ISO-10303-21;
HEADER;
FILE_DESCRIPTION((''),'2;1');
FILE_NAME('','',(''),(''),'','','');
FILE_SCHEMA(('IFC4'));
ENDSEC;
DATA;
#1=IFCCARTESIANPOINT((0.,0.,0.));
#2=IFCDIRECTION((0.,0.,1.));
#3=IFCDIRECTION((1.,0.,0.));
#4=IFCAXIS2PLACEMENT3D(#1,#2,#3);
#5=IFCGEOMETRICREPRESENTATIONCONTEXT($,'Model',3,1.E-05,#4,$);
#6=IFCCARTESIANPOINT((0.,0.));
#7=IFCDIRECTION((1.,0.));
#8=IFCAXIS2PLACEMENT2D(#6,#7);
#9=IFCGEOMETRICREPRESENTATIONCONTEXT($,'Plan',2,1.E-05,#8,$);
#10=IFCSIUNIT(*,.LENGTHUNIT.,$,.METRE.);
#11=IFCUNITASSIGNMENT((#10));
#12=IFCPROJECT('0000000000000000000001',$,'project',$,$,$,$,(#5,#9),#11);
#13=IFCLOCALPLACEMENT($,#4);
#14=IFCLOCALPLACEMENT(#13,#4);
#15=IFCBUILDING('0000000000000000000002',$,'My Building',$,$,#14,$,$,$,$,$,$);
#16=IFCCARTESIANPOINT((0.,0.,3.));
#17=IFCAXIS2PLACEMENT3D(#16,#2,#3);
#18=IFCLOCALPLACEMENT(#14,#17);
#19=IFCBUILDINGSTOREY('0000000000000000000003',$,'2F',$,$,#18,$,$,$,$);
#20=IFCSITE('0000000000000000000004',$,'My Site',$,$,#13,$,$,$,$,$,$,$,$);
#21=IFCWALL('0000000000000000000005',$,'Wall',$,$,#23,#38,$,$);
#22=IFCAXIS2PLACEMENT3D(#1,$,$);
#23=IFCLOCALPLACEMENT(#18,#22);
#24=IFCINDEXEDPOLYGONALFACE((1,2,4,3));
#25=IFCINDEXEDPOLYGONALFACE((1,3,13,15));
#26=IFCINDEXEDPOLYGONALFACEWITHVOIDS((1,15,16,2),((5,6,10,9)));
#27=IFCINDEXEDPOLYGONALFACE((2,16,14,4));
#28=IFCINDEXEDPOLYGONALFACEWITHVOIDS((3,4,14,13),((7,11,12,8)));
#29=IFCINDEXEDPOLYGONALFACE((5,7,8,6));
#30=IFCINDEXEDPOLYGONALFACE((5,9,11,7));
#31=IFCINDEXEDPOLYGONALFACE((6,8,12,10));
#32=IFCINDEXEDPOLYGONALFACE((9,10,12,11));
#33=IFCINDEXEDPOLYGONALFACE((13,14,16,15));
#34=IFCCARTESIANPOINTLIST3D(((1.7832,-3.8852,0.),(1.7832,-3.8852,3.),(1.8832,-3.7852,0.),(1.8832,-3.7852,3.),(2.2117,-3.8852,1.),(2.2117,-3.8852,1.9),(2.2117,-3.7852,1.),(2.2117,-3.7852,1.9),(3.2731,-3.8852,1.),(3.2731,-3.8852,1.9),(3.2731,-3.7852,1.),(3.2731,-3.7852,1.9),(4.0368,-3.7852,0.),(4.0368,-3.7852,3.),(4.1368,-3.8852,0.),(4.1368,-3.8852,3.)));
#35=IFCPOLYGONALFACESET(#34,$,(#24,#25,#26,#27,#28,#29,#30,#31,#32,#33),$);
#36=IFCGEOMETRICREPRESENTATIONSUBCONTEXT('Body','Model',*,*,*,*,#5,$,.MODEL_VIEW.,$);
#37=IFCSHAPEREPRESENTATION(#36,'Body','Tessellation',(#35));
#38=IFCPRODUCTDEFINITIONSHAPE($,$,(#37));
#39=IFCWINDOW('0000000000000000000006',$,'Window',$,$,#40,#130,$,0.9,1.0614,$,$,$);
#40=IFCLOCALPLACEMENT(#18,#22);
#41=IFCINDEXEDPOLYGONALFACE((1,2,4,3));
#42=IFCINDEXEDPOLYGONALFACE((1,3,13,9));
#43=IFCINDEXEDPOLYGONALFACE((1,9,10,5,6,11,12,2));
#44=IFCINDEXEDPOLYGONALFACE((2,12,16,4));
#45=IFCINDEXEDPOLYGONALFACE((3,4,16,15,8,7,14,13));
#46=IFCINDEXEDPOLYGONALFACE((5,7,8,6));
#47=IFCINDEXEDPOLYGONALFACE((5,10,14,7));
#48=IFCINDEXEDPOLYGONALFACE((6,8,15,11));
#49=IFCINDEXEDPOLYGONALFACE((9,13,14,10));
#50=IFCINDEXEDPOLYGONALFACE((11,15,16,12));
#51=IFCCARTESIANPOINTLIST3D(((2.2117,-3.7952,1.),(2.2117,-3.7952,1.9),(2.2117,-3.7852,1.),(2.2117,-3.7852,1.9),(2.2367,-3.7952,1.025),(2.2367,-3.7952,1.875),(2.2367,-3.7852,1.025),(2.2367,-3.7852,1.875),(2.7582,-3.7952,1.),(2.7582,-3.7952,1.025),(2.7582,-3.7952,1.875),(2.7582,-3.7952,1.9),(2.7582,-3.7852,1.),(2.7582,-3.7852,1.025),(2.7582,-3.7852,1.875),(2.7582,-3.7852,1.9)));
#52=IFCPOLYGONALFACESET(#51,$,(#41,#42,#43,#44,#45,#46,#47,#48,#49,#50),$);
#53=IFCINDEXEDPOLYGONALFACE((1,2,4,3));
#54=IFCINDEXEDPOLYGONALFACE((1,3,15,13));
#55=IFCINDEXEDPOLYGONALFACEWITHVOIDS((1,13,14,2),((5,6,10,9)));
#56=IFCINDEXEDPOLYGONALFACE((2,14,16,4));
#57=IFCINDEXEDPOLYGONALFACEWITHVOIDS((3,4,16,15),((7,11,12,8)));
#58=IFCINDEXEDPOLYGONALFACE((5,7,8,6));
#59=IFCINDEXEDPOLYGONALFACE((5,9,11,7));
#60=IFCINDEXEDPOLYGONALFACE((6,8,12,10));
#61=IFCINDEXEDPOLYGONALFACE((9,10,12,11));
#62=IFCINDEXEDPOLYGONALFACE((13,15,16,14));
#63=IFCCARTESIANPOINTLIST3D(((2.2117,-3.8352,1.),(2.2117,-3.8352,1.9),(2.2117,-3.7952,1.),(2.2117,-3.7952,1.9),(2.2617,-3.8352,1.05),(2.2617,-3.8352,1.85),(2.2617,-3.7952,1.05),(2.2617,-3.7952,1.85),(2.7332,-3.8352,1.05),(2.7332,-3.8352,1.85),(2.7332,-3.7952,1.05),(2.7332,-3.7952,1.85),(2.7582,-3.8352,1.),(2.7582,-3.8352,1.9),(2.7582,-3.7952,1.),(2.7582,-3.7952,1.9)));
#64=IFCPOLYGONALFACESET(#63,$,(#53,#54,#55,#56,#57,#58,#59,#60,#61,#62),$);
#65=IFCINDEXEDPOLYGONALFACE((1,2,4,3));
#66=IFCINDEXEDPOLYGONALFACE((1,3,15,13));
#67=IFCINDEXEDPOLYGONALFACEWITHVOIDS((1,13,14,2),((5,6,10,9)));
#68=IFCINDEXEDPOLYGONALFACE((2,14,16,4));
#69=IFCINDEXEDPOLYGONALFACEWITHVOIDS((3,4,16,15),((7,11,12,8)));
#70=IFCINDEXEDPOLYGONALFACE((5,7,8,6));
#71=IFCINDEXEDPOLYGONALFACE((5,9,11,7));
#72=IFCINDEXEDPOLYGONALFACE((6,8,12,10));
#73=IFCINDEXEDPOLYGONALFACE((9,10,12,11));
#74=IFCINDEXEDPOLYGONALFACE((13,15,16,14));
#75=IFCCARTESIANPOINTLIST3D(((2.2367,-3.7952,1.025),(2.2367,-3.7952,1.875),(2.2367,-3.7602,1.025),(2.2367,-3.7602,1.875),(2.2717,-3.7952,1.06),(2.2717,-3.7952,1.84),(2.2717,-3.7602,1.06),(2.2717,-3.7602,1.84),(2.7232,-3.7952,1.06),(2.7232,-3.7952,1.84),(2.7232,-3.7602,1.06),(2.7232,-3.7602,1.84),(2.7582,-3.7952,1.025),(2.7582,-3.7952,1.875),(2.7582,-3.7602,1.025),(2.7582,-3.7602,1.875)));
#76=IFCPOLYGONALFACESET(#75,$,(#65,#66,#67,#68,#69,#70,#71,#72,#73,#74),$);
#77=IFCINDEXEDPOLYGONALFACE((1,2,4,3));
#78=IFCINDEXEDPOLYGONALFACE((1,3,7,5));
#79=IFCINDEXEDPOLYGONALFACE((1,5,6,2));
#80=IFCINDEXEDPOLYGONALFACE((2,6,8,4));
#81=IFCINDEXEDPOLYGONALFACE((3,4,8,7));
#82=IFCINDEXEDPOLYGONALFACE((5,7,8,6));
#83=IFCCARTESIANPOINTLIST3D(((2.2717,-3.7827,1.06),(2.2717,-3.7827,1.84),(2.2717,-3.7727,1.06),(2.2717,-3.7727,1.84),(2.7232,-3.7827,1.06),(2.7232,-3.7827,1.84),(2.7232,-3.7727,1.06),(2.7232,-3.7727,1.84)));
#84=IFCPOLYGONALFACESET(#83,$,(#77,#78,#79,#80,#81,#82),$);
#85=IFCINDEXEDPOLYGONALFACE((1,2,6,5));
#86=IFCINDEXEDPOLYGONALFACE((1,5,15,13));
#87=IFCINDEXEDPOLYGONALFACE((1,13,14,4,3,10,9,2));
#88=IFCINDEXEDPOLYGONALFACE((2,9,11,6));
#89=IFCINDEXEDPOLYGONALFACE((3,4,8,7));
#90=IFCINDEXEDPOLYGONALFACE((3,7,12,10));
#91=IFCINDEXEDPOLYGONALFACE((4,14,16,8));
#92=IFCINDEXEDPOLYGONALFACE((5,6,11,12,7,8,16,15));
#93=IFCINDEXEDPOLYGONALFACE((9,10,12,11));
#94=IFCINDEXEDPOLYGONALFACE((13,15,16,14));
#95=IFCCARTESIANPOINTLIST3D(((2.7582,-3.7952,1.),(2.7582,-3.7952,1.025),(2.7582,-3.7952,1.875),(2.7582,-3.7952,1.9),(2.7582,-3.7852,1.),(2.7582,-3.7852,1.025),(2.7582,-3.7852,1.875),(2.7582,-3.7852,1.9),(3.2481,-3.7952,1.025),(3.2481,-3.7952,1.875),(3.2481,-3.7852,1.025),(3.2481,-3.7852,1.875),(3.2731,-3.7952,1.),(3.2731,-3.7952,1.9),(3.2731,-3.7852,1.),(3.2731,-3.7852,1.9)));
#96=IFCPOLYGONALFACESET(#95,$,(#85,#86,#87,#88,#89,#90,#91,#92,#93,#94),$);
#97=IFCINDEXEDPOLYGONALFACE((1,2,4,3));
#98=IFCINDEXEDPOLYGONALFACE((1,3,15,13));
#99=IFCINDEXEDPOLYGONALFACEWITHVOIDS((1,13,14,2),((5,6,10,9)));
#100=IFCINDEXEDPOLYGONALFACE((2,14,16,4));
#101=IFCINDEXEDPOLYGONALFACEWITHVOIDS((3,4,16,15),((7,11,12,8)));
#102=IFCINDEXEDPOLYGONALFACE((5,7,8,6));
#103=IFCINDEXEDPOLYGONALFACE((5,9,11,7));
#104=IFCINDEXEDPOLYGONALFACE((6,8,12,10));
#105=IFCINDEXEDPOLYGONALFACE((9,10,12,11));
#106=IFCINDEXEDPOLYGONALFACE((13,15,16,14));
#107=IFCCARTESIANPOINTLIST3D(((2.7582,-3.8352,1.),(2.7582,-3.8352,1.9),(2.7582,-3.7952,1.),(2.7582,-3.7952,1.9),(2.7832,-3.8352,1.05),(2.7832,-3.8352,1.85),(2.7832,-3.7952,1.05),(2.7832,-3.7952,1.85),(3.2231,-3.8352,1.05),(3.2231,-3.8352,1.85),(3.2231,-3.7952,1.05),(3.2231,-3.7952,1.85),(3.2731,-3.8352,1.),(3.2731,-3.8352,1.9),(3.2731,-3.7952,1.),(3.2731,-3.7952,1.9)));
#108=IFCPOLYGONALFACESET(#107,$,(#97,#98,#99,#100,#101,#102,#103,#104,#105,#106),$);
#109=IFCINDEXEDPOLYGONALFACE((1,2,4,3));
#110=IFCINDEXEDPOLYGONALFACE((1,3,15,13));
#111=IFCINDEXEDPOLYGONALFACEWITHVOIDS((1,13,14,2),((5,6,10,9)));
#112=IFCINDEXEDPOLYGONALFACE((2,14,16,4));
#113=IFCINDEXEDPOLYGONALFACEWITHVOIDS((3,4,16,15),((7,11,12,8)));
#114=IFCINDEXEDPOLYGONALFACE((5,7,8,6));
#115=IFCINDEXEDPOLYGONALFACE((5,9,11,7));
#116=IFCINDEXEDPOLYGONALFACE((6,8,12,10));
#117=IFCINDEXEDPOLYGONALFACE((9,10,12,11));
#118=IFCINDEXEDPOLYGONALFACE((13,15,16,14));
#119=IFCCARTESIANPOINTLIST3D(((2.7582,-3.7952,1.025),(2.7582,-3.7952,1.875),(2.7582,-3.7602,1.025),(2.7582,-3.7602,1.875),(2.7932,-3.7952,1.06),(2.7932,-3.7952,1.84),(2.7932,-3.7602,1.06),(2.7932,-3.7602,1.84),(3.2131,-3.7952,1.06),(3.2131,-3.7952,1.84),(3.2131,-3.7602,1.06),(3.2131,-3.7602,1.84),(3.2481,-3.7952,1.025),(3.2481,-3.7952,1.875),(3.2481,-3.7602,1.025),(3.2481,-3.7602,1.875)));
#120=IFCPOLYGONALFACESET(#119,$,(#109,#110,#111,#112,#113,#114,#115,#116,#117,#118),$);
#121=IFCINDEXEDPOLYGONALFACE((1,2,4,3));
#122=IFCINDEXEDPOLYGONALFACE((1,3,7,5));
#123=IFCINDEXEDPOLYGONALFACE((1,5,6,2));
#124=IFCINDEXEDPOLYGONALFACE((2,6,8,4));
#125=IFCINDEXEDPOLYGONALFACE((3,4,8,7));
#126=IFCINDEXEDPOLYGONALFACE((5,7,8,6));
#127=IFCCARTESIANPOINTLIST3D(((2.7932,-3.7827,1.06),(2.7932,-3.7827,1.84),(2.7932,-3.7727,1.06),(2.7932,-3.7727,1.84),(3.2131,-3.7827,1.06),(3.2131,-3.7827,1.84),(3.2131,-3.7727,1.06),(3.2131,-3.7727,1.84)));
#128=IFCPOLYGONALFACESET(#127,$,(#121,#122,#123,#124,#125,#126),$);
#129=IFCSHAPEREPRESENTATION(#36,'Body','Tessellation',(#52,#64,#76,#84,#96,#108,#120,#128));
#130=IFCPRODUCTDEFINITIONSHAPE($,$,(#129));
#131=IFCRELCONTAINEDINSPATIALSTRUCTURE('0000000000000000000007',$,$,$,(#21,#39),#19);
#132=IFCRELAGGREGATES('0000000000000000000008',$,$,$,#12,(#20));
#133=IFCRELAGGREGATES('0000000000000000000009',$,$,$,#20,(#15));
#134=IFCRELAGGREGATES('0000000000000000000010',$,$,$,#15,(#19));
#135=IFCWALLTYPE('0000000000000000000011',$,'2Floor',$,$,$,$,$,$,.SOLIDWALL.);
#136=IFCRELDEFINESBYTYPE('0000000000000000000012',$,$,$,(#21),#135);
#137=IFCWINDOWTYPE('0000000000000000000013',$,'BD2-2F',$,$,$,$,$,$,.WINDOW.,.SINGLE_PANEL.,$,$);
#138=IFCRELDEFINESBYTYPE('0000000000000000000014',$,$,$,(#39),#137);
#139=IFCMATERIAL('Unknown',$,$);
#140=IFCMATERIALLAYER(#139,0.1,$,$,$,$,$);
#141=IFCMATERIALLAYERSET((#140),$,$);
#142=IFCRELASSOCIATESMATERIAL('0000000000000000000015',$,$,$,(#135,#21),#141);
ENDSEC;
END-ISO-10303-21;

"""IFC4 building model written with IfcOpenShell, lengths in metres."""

from ifc_helpers import new_model, entity, si_unit, frame, origin_with_axes, origin_2d_with_axis, place, context, subcontext, project, spatial, line, indexed_curve, outline, extrude, shape, source, transform, mapped, material, layer, layer_set, layer_usage, type_object, type_shapes, element, fill, save


model = new_model("IFC4")

# Units and contexts
model_context = context("Model", 3, precision=1e-05, world=origin_with_axes())
plan_context = context("Plan", 2, precision=1e-05, world=origin_2d_with_axis())
body_context_1 = subcontext(model_context, "Body", "Model", "MODEL_VIEW")
body_context_2 = subcontext(plan_context, "Body", "Plan", "PLAN_VIEW")
ifc_project = project(units=[si_unit("LENGTHUNIT", "METRE")], contexts=[model_context, plan_context])

# Site, building, storey
site_placement = place(None, origin_with_axes())
site = spatial("IfcSite", under=ifc_project, at=site_placement, Name="My Site")
building_placement = place(site_placement, origin_with_axes())
building = spatial("IfcBuilding", under=site, at=building_placement, Name="My Building")
storey_placement = place(building_placement, frame((0.0, 0.0, 3.0), z_axis=(0.0, 0.0, 1.0), x_axis=(1.0, 0.0, 0.0)))
storey = spatial("IfcBuildingStorey", under=building, at=storey_placement, Name="2F")

# Shared definitions
ifc_material = material(Name="Unknown")

# Shared definitions
ifc_layer_1 = layer(ifc_material, 0.1)
ifc_layer_set_1 = layer_set([ifc_layer_1])
wall_type = type_object("IfcWallType", Name="2Floor", PredefinedType="SOLIDWALL", material=ifc_layer_set_1)

# Wall, opening, window
ifc_layer_usage_1 = layer_usage(ifc_layer_set_1, "AXIS2", "POSITIVE", 0.0)
wall_1_placement = place(storey_placement, frame((1.7832, -3.8852, 0.0), z_axis=(0.0, 0.0, 1.0), x_axis=(1.0, 0.000014, 0.0)))
wall_1 = element("IfcWall", 1, at=wall_1_placement, inside=storey, type_object=wall_type, material=ifc_layer_usage_1, Name="Wall", context=body_context_1, shape_type="SweptSolid", body=[
    extrude(outline(indexed_curve([(0.0, 0.0), (0.1, 0.1), (2.2537, 0.1), (2.3537, 0.0)], segments=[line(1, 2, 3, 4, 1)])), origin_with_axes(), (0.0, 0.0, 1.0), 3.0),
])
shared_shape_1 = source(origin_with_axes(), body_context_1, "Body", "SweptSolid", [
    extrude(outline(indexed_curve([(0.0, 0.0), (1.0614, 0.0), (1.0614, 0.9), (0.0, 0.9)], segments=[line(1, 2, 3, 4, 1)])), frame((0.0, -0.6, 0.0), z_axis=(0.0, -1.0, 0.0), x_axis=(1.0, 0.0, 0.0)), (0.0, 0.0, -1.0), 1.2),
])
opening_1_placement = place(wall_1_placement, frame((0.4285, 0.0, 1.0), z_axis=(0.0, 0.0, 1.0), x_axis=(1.0, 0.0, 0.0)))
opening_1 = element("IfcOpeningElement", 2, at=opening_1_placement, cuts=wall_1, PredefinedType="OPENING", context=body_context_1, shape_type="MappedRepresentation", body=[
    mapped(shared_shape_1, transform((0.0, 0.0, 0.0), x_axis=(1.0, 0.0, 0.0), y_axis=(0.0, 1.0, 0.0), z_axis=(0.0, 0.0, 1.0), scale=1.0)),
])
window_type_1 = type_object("IfcWindowType", Name="BD2-2F", PartitioningType="SINGLE_PANEL", PredefinedType="WINDOW")
shared_shape_2 = source(origin_with_axes(), body_context_1, "Body", "SweptSolid", [
    extrude(outline(indexed_curve([(0.5465, 0.0), (0.0, 0.0), (0.0, 0.9), (0.5465, 0.9), (0.5465, 0.875), (0.025, 0.875), (0.025, 0.025), (0.5465, 0.025)], segments=[line(1, 2, 3, 4, 5, 6, 7, 8, 1)])), frame((0.0, 0.09, 0.0), z_axis=(0.0, -1.0, 0.0), x_axis=(1.0, 0.0, 0.0)), (0.0, 0.0, -1.0), 0.01),
    extrude(outline(indexed_curve([(0.0, 0.0), (0.5465, 0.0), (0.5465, 0.9), (0.0, 0.9)], segments=[line(1, 2, 3, 4, 1)]), holes=[indexed_curve([(0.05, 0.05), (0.5215, 0.05), (0.5215, 0.85), (0.05, 0.85)], segments=[line(1, 2, 3, 4, 1)])]), frame((0.0, 0.05, 0.0), z_axis=(0.0, -1.0, 0.0), x_axis=(1.0, 0.0, 0.0)), (0.0, 0.0, -1.0), 0.04),
    extrude(outline(indexed_curve([(0.0, 0.0), (0.5215, 0.0), (0.5215, 0.85), (0.0, 0.85)], segments=[line(1, 2, 3, 4, 1)]), holes=[indexed_curve([(0.035, 0.035), (0.4865, 0.035), (0.4865, 0.815), (0.035, 0.815)], segments=[line(1, 2, 3, 4, 1)])]), frame((0.025, 0.09, 0.025), z_axis=(0.0, -1.0, 0.0), x_axis=(1.0, 0.0, 0.0)), (0.0, 0.0, -1.0), 0.035),
    extrude(outline(indexed_curve([(0.035, 0.035), (0.4865, 0.035), (0.4865, 0.815), (0.035, 0.815)], segments=[line(1, 2, 3, 4, 1)])), frame((0.025, 0.1025, 0.025), z_axis=(0.0, -1.0, 0.0), x_axis=(1.0, 0.0, 0.0)), (0.0, 0.0, -1.0), 0.01),
    extrude(outline(indexed_curve([(0.0, 0.9), (0.5149, 0.9), (0.5149, 0.0), (0.0, 0.0), (0.0, 0.025), (0.4899, 0.025), (0.4899, 0.875), (0.0, 0.875)], segments=[line(1, 2, 3, 4, 5, 6, 7, 8, 1)])), frame((0.5465, 0.09, 0.0), z_axis=(0.0, -1.0, 0.0), x_axis=(1.0, 0.0, 0.0)), (0.0, 0.0, -1.0), 0.01),
    extrude(outline(indexed_curve([(0.0, 0.0), (0.5149, 0.0), (0.5149, 0.9), (0.0, 0.9)], segments=[line(1, 2, 3, 4, 1)]), holes=[indexed_curve([(0.025, 0.05), (0.4649, 0.05), (0.4649, 0.85), (0.025, 0.85)], segments=[line(1, 2, 3, 4, 1)])]), frame((0.5465, 0.05, 0.0), z_axis=(0.0, -1.0, 0.0), x_axis=(1.0, 0.0, 0.0)), (0.0, 0.0, -1.0), 0.04),
    extrude(outline(indexed_curve([(0.0, 0.0), (0.4899, 0.0), (0.4899, 0.85), (0.0, 0.85)], segments=[line(1, 2, 3, 4, 1)]), holes=[indexed_curve([(0.035, 0.035), (0.4549, 0.035), (0.4549, 0.815), (0.035, 0.815)], segments=[line(1, 2, 3, 4, 1)])]), frame((0.5465, 0.09, 0.025), z_axis=(0.0, -1.0, 0.0), x_axis=(1.0, 0.0, 0.0)), (0.0, 0.0, -1.0), 0.035),
    extrude(outline(indexed_curve([(0.035, 0.035), (0.4549, 0.035), (0.4549, 0.815), (0.035, 0.815)], segments=[line(1, 2, 3, 4, 1)])), frame((0.5465, 0.1025, 0.025), z_axis=(0.0, -1.0, 0.0), x_axis=(1.0, 0.0, 0.0)), (0.0, 0.0, -1.0), 0.01),
])
shared_shape_3 = source(origin_with_axes(), body_context_2, "Body", "Curve2D", [
    entity("IfcIndexedPolyCurve", entity("IfcCartesianPointList2D", [[0.05, 0.05], [0.5215, 0.05]])),
    entity("IfcIndexedPolyCurve", entity("IfcCartesianPointList2D", [[0.0, 0.1], [0.025, 0.1], [0.025, 0.09], [0.05, 0.09], [0.05, 0.05], [0.0, 0.05]]), [entity("IfcLineIndex", [1, 2, 3, 4, 5, 6, 1])]),
    entity("IfcIndexedPolyCurve", entity("IfcCartesianPointList2D", [[0.5465, 0.1], [0.5465, 0.1], [0.5465, 0.09], [0.5215, 0.09], [0.5215, 0.05], [0.5465, 0.05]])),
    entity("IfcIndexedPolyCurve", entity("IfcCartesianPointList2D", [[0.025, 0.09], [0.06, 0.09], [0.06, 0.125], [0.025, 0.125]]), [entity("IfcLineIndex", [1, 2, 3, 4, 1])]),
    entity("IfcIndexedPolyCurve", entity("IfcCartesianPointList2D", [[0.5465, 0.09], [0.5115, 0.09], [0.5115, 0.125], [0.5465, 0.125]]), [entity("IfcLineIndex", [1, 2, 3, 4, 1])]),
    entity("IfcIndexedPolyCurve", entity("IfcCartesianPointList2D", [[0.06, 0.09], [0.5115, 0.09]])),
    entity("IfcIndexedPolyCurve", entity("IfcCartesianPointList2D", [[0.06, 0.125], [0.5115, 0.125]])),
    entity("IfcIndexedPolyCurve", entity("IfcCartesianPointList2D", [[0.06, 0.1075], [0.5115, 0.1075]])),
    entity("IfcIndexedPolyCurve", entity("IfcCartesianPointList2D", [[0.5715, 0.05], [1.0114, 0.05]])),
    entity("IfcIndexedPolyCurve", entity("IfcCartesianPointList2D", [[0.5465, 0.1], [0.5465, 0.1], [0.5465, 0.09], [0.5715, 0.09], [0.5715, 0.05], [0.5465, 0.05]])),
    entity("IfcIndexedPolyCurve", entity("IfcCartesianPointList2D", [[1.0614, 0.1], [1.0364, 0.1], [1.0364, 0.09], [1.0114, 0.09], [1.0114, 0.05], [1.0614, 0.05]]), [entity("IfcLineIndex", [1, 2, 3, 4, 5, 6, 1])]),
    entity("IfcIndexedPolyCurve", entity("IfcCartesianPointList2D", [[0.5465, 0.09], [0.5815, 0.09], [0.5815, 0.125], [0.5465, 0.125]]), [entity("IfcLineIndex", [1, 2, 3, 4, 1])]),
    entity("IfcIndexedPolyCurve", entity("IfcCartesianPointList2D", [[1.0364, 0.09], [1.0014, 0.09], [1.0014, 0.125], [1.0364, 0.125]]), [entity("IfcLineIndex", [1, 2, 3, 4, 1])]),
    entity("IfcIndexedPolyCurve", entity("IfcCartesianPointList2D", [[0.5815, 0.09], [1.0014, 0.09]])),
    entity("IfcIndexedPolyCurve", entity("IfcCartesianPointList2D", [[0.5815, 0.125], [1.0014, 0.125]])),
    entity("IfcIndexedPolyCurve", entity("IfcCartesianPointList2D", [[0.5815, 0.1075], [1.0014, 0.1075]])),
])
type_shapes(window_type_1, [shared_shape_2, shared_shape_3])
window_1_placement = place(opening_1_placement, frame((0.0, 0.0, 0.0), z_axis=(0.0, 0.0, 1.0), x_axis=(1.0, 0.0, 0.0)))
window_1 = element("IfcWindow", 3, at=window_1_placement, inside=storey, type_object=window_type_1, Name="Window", OverallHeight=0.9, OverallWidth=1.0614, shapes=[
    shape(body_context_1, "Body", "MappedRepresentation", [mapped(shared_shape_2, transform((0.0, 0.0, 0.0), x_axis=(1.0, 0.0, 0.0), y_axis=(0.0, 1.0, 0.0), z_axis=(0.0, 0.0, 1.0), scale=1.0))]),
    shape(body_context_2, "Body", "MappedRepresentation", [mapped(shared_shape_3, transform((0.0, 0.0, 0.0), x_axis=(1.0, 0.0, 0.0), y_axis=(0.0, 1.0, 0.0), z_axis=(0.0, 0.0, 1.0), scale=1.0))]),
])
fill(opening_1, window_1)

save(model, "model.ifc")
